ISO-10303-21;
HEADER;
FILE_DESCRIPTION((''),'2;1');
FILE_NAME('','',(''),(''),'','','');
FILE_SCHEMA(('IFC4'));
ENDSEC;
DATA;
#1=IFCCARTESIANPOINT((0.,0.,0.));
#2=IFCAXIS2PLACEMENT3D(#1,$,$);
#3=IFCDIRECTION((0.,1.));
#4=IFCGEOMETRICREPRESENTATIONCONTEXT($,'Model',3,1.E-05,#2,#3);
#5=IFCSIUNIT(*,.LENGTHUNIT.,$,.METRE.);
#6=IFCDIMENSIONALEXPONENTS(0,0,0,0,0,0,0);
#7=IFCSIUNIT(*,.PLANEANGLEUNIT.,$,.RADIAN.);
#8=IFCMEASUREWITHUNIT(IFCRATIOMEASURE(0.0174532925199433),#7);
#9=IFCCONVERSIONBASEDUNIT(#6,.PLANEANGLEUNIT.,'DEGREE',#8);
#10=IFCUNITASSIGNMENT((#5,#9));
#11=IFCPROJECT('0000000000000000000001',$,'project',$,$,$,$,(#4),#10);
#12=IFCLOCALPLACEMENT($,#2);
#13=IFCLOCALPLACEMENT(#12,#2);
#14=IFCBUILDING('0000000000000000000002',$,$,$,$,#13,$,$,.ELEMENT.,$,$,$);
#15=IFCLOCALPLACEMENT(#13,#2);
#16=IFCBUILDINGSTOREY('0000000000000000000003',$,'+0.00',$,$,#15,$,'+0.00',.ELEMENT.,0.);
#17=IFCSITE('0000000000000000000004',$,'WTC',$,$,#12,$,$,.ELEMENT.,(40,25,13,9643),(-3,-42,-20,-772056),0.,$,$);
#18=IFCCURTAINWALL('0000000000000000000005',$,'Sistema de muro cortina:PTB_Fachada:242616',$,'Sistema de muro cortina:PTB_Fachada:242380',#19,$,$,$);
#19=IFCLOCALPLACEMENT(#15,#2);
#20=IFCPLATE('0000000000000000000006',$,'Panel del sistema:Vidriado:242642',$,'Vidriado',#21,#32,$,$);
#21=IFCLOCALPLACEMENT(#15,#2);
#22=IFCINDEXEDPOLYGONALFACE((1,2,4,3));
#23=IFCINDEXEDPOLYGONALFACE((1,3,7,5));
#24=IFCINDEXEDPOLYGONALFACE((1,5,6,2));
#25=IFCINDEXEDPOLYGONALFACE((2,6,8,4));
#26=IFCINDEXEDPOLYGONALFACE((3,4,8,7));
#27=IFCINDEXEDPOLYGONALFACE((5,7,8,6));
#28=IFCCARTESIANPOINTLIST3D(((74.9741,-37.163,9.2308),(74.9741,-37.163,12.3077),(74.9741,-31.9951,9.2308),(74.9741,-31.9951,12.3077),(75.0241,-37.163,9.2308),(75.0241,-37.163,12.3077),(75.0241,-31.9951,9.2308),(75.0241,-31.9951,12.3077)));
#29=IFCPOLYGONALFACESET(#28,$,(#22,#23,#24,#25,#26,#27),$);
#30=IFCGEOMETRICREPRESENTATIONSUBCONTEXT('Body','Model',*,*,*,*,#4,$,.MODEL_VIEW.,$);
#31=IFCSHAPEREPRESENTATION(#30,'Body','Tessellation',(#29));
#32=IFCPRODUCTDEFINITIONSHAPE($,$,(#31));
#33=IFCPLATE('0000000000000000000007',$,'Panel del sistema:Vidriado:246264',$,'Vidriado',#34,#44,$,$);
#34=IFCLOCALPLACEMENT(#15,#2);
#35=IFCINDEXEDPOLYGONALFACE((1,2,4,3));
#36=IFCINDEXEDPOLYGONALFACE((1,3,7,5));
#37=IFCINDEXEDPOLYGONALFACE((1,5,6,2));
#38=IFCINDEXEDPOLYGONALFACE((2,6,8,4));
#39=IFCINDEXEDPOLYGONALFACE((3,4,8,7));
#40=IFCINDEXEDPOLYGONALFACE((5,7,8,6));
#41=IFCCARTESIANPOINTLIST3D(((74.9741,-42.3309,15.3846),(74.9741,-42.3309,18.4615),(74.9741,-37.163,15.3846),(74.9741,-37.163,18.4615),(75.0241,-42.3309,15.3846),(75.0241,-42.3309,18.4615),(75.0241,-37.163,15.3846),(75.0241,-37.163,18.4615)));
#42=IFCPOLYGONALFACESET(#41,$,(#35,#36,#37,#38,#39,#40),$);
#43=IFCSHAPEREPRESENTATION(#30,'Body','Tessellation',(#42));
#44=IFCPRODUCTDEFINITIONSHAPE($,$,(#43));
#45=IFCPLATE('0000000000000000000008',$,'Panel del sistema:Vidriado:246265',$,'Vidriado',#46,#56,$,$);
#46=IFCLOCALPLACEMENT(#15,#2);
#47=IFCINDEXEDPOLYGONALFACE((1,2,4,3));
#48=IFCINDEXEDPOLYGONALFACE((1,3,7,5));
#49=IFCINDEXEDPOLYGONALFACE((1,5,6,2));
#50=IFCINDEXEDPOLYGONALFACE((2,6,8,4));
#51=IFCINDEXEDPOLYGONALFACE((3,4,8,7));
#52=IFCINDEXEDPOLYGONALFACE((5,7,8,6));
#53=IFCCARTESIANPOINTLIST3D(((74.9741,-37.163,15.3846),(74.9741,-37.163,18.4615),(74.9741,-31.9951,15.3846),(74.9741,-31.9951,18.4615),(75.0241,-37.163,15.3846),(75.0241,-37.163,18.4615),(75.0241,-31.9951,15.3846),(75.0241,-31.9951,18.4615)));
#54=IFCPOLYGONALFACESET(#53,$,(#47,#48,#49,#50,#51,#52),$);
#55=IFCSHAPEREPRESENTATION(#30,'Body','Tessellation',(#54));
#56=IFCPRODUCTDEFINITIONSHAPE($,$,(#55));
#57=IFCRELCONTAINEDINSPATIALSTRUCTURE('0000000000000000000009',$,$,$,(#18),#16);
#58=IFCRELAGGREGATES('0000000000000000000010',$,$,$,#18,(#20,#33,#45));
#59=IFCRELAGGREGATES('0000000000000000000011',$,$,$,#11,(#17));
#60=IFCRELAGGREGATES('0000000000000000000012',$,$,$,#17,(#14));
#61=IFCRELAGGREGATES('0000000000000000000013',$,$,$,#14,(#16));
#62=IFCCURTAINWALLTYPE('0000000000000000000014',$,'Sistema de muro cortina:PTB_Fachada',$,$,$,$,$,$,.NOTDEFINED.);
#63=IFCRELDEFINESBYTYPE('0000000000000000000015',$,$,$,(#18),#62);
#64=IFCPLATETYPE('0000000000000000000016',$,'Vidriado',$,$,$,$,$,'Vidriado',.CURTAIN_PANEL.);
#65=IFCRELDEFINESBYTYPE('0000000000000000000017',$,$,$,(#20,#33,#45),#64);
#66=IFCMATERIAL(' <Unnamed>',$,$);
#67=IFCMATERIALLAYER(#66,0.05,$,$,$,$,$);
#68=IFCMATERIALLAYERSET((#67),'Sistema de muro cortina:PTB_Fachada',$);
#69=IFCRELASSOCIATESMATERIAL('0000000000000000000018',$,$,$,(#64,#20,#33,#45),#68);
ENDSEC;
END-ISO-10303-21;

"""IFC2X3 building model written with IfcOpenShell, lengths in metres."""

from ifc_helpers import new_model, entity, si_unit, converted_unit, direction, frame, origin, origin_2d_with_axis, place, context, subcontext, project, spatial, rectangle, extrude, source, transform, mapped, material, layer, layer_set, layer_usage, type_object, type_shapes, element, aggregate, save


model = new_model("IFC2X3")

# Units and contexts
model_context = context("Model", 3, precision=1e-05, world=origin(), true_north=direction((0.0, 1.0)))
body_context = subcontext(model_context, "Body", "Model", "MODEL_VIEW")
ifc_project = project(units=[si_unit("LENGTHUNIT", "METRE"), converted_unit("PLANEANGLEUNIT", "DEGREE", entity("IfcRatioMeasure", 0.0174532925199433), si_unit("PLANEANGLEUNIT", "RADIAN"), dimensions=[0, 0, 0, 0, 0, 0, 0])], contexts=[model_context])

# Site, building, storey
site_placement = place(None, origin())
site = spatial("IfcSite", under=ifc_project, at=site_placement, Name="WTC", CompositionType="ELEMENT", RefLatitude=(40, 25, 13, 9643), RefLongitude=(-3, -42, -20, -772056), RefElevation=0.0)
building_placement = place(site_placement, origin())
building = spatial("IfcBuilding", under=site, at=building_placement, CompositionType="ELEMENT")
storey_placement = place(building_placement, origin())
storey = spatial("IfcBuildingStorey", under=building, at=storey_placement, Name="+0.00", LongName="+0.00", CompositionType="ELEMENT", Elevation=0.0)

# Curtain wall, plates
curtain_wall_type = type_object("IfcCurtainWallType", Name="Sistema de muro cortina:PTB_Fachada", PredefinedType="NOTDEFINED")
ifc_material = material(Name=" <Unnamed>")
ifc_layer_1 = layer(ifc_material, 0.05)
ifc_layer_set_1 = layer_set([ifc_layer_1], Name="Sistema de muro cortina:PTB_Fachada")
curtain_wall_1_placement = place(storey_placement, origin())
curtain_wall_1 = element("IfcCurtainWall", 1, at=curtain_wall_1_placement, inside=storey, type_object=curtain_wall_type, Name="Sistema de muro cortina:PTB_Fachada:242616", ObjectType="Sistema de muro cortina:PTB_Fachada:242380")
plate_type_1 = type_object("IfcPlateType", Name="Vidriado", ElementType="Vidriado", PredefinedType="CURTAIN_PANEL", material=ifc_layer_set_1)
shared_shape_1 = source(origin(), body_context, "Body", "SweptSolid", [
    extrude(rectangle(XDim=0.05, YDim=5.1679, at=origin_2d_with_axis()), frame((0.0, 0.0, 0.0), z_axis=(0.0, 0.0, 1.0), x_axis=(0.0, 1.0, 0.0)), (0.0, 0.0, 1.0), 3.0769),
])
type_shapes(plate_type_1, [shared_shape_1])
ifc_layer_usage_1 = layer_usage(ifc_layer_set_1, "AXIS3", "POSITIVE", 0.0)
plate_1_placement = place(curtain_wall_1_placement, frame((74.9991, -34.5791, 9.2308), z_axis=(0.0, 0.0, 1.0), x_axis=(0.0, 1.0, 0.0)))
plate_1 = element("IfcPlate", 2, at=plate_1_placement, type_object=plate_type_1, material=ifc_layer_usage_1, Name="Panel del sistema:Vidriado:242642", ObjectType="Vidriado", context=body_context, shape_type="MappedRepresentation", body=[
    mapped(shared_shape_1, transform((0.0, 0.0, 0.0), scale=1.0)),
])
ifc_layer_usage_2 = layer_usage(ifc_layer_set_1, "AXIS3", "POSITIVE", 0.0)
plate_2_placement = place(curtain_wall_1_placement, frame((74.9991, -39.747, 15.3846), z_axis=(0.0, 0.0, 1.0), x_axis=(0.0, 1.0, 0.0)))
plate_2 = element("IfcPlate", 3, at=plate_2_placement, type_object=plate_type_1, material=ifc_layer_usage_2, Name="Panel del sistema:Vidriado:246264", ObjectType="Vidriado", context=body_context, shape_type="MappedRepresentation", body=[
    mapped(shared_shape_1, transform((0.0, 0.0, 0.0), scale=1.0)),
])
ifc_layer_usage_3 = layer_usage(ifc_layer_set_1, "AXIS3", "POSITIVE", 0.0)
plate_3_placement = place(curtain_wall_1_placement, frame((74.9991, -34.5791, 15.3846), z_axis=(0.0, 0.0, 1.0), x_axis=(0.0, 1.0, 0.0)))
plate_3 = element("IfcPlate", 4, at=plate_3_placement, type_object=plate_type_1, material=ifc_layer_usage_3, Name="Panel del sistema:Vidriado:246265", ObjectType="Vidriado", context=body_context, shape_type="MappedRepresentation", body=[
    mapped(shared_shape_1, transform((0.0, 0.0, 0.0), scale=1.0)),
])
aggregate(curtain_wall_1, [plate_1, plate_2, plate_3])

save(model, "model.ifc")
